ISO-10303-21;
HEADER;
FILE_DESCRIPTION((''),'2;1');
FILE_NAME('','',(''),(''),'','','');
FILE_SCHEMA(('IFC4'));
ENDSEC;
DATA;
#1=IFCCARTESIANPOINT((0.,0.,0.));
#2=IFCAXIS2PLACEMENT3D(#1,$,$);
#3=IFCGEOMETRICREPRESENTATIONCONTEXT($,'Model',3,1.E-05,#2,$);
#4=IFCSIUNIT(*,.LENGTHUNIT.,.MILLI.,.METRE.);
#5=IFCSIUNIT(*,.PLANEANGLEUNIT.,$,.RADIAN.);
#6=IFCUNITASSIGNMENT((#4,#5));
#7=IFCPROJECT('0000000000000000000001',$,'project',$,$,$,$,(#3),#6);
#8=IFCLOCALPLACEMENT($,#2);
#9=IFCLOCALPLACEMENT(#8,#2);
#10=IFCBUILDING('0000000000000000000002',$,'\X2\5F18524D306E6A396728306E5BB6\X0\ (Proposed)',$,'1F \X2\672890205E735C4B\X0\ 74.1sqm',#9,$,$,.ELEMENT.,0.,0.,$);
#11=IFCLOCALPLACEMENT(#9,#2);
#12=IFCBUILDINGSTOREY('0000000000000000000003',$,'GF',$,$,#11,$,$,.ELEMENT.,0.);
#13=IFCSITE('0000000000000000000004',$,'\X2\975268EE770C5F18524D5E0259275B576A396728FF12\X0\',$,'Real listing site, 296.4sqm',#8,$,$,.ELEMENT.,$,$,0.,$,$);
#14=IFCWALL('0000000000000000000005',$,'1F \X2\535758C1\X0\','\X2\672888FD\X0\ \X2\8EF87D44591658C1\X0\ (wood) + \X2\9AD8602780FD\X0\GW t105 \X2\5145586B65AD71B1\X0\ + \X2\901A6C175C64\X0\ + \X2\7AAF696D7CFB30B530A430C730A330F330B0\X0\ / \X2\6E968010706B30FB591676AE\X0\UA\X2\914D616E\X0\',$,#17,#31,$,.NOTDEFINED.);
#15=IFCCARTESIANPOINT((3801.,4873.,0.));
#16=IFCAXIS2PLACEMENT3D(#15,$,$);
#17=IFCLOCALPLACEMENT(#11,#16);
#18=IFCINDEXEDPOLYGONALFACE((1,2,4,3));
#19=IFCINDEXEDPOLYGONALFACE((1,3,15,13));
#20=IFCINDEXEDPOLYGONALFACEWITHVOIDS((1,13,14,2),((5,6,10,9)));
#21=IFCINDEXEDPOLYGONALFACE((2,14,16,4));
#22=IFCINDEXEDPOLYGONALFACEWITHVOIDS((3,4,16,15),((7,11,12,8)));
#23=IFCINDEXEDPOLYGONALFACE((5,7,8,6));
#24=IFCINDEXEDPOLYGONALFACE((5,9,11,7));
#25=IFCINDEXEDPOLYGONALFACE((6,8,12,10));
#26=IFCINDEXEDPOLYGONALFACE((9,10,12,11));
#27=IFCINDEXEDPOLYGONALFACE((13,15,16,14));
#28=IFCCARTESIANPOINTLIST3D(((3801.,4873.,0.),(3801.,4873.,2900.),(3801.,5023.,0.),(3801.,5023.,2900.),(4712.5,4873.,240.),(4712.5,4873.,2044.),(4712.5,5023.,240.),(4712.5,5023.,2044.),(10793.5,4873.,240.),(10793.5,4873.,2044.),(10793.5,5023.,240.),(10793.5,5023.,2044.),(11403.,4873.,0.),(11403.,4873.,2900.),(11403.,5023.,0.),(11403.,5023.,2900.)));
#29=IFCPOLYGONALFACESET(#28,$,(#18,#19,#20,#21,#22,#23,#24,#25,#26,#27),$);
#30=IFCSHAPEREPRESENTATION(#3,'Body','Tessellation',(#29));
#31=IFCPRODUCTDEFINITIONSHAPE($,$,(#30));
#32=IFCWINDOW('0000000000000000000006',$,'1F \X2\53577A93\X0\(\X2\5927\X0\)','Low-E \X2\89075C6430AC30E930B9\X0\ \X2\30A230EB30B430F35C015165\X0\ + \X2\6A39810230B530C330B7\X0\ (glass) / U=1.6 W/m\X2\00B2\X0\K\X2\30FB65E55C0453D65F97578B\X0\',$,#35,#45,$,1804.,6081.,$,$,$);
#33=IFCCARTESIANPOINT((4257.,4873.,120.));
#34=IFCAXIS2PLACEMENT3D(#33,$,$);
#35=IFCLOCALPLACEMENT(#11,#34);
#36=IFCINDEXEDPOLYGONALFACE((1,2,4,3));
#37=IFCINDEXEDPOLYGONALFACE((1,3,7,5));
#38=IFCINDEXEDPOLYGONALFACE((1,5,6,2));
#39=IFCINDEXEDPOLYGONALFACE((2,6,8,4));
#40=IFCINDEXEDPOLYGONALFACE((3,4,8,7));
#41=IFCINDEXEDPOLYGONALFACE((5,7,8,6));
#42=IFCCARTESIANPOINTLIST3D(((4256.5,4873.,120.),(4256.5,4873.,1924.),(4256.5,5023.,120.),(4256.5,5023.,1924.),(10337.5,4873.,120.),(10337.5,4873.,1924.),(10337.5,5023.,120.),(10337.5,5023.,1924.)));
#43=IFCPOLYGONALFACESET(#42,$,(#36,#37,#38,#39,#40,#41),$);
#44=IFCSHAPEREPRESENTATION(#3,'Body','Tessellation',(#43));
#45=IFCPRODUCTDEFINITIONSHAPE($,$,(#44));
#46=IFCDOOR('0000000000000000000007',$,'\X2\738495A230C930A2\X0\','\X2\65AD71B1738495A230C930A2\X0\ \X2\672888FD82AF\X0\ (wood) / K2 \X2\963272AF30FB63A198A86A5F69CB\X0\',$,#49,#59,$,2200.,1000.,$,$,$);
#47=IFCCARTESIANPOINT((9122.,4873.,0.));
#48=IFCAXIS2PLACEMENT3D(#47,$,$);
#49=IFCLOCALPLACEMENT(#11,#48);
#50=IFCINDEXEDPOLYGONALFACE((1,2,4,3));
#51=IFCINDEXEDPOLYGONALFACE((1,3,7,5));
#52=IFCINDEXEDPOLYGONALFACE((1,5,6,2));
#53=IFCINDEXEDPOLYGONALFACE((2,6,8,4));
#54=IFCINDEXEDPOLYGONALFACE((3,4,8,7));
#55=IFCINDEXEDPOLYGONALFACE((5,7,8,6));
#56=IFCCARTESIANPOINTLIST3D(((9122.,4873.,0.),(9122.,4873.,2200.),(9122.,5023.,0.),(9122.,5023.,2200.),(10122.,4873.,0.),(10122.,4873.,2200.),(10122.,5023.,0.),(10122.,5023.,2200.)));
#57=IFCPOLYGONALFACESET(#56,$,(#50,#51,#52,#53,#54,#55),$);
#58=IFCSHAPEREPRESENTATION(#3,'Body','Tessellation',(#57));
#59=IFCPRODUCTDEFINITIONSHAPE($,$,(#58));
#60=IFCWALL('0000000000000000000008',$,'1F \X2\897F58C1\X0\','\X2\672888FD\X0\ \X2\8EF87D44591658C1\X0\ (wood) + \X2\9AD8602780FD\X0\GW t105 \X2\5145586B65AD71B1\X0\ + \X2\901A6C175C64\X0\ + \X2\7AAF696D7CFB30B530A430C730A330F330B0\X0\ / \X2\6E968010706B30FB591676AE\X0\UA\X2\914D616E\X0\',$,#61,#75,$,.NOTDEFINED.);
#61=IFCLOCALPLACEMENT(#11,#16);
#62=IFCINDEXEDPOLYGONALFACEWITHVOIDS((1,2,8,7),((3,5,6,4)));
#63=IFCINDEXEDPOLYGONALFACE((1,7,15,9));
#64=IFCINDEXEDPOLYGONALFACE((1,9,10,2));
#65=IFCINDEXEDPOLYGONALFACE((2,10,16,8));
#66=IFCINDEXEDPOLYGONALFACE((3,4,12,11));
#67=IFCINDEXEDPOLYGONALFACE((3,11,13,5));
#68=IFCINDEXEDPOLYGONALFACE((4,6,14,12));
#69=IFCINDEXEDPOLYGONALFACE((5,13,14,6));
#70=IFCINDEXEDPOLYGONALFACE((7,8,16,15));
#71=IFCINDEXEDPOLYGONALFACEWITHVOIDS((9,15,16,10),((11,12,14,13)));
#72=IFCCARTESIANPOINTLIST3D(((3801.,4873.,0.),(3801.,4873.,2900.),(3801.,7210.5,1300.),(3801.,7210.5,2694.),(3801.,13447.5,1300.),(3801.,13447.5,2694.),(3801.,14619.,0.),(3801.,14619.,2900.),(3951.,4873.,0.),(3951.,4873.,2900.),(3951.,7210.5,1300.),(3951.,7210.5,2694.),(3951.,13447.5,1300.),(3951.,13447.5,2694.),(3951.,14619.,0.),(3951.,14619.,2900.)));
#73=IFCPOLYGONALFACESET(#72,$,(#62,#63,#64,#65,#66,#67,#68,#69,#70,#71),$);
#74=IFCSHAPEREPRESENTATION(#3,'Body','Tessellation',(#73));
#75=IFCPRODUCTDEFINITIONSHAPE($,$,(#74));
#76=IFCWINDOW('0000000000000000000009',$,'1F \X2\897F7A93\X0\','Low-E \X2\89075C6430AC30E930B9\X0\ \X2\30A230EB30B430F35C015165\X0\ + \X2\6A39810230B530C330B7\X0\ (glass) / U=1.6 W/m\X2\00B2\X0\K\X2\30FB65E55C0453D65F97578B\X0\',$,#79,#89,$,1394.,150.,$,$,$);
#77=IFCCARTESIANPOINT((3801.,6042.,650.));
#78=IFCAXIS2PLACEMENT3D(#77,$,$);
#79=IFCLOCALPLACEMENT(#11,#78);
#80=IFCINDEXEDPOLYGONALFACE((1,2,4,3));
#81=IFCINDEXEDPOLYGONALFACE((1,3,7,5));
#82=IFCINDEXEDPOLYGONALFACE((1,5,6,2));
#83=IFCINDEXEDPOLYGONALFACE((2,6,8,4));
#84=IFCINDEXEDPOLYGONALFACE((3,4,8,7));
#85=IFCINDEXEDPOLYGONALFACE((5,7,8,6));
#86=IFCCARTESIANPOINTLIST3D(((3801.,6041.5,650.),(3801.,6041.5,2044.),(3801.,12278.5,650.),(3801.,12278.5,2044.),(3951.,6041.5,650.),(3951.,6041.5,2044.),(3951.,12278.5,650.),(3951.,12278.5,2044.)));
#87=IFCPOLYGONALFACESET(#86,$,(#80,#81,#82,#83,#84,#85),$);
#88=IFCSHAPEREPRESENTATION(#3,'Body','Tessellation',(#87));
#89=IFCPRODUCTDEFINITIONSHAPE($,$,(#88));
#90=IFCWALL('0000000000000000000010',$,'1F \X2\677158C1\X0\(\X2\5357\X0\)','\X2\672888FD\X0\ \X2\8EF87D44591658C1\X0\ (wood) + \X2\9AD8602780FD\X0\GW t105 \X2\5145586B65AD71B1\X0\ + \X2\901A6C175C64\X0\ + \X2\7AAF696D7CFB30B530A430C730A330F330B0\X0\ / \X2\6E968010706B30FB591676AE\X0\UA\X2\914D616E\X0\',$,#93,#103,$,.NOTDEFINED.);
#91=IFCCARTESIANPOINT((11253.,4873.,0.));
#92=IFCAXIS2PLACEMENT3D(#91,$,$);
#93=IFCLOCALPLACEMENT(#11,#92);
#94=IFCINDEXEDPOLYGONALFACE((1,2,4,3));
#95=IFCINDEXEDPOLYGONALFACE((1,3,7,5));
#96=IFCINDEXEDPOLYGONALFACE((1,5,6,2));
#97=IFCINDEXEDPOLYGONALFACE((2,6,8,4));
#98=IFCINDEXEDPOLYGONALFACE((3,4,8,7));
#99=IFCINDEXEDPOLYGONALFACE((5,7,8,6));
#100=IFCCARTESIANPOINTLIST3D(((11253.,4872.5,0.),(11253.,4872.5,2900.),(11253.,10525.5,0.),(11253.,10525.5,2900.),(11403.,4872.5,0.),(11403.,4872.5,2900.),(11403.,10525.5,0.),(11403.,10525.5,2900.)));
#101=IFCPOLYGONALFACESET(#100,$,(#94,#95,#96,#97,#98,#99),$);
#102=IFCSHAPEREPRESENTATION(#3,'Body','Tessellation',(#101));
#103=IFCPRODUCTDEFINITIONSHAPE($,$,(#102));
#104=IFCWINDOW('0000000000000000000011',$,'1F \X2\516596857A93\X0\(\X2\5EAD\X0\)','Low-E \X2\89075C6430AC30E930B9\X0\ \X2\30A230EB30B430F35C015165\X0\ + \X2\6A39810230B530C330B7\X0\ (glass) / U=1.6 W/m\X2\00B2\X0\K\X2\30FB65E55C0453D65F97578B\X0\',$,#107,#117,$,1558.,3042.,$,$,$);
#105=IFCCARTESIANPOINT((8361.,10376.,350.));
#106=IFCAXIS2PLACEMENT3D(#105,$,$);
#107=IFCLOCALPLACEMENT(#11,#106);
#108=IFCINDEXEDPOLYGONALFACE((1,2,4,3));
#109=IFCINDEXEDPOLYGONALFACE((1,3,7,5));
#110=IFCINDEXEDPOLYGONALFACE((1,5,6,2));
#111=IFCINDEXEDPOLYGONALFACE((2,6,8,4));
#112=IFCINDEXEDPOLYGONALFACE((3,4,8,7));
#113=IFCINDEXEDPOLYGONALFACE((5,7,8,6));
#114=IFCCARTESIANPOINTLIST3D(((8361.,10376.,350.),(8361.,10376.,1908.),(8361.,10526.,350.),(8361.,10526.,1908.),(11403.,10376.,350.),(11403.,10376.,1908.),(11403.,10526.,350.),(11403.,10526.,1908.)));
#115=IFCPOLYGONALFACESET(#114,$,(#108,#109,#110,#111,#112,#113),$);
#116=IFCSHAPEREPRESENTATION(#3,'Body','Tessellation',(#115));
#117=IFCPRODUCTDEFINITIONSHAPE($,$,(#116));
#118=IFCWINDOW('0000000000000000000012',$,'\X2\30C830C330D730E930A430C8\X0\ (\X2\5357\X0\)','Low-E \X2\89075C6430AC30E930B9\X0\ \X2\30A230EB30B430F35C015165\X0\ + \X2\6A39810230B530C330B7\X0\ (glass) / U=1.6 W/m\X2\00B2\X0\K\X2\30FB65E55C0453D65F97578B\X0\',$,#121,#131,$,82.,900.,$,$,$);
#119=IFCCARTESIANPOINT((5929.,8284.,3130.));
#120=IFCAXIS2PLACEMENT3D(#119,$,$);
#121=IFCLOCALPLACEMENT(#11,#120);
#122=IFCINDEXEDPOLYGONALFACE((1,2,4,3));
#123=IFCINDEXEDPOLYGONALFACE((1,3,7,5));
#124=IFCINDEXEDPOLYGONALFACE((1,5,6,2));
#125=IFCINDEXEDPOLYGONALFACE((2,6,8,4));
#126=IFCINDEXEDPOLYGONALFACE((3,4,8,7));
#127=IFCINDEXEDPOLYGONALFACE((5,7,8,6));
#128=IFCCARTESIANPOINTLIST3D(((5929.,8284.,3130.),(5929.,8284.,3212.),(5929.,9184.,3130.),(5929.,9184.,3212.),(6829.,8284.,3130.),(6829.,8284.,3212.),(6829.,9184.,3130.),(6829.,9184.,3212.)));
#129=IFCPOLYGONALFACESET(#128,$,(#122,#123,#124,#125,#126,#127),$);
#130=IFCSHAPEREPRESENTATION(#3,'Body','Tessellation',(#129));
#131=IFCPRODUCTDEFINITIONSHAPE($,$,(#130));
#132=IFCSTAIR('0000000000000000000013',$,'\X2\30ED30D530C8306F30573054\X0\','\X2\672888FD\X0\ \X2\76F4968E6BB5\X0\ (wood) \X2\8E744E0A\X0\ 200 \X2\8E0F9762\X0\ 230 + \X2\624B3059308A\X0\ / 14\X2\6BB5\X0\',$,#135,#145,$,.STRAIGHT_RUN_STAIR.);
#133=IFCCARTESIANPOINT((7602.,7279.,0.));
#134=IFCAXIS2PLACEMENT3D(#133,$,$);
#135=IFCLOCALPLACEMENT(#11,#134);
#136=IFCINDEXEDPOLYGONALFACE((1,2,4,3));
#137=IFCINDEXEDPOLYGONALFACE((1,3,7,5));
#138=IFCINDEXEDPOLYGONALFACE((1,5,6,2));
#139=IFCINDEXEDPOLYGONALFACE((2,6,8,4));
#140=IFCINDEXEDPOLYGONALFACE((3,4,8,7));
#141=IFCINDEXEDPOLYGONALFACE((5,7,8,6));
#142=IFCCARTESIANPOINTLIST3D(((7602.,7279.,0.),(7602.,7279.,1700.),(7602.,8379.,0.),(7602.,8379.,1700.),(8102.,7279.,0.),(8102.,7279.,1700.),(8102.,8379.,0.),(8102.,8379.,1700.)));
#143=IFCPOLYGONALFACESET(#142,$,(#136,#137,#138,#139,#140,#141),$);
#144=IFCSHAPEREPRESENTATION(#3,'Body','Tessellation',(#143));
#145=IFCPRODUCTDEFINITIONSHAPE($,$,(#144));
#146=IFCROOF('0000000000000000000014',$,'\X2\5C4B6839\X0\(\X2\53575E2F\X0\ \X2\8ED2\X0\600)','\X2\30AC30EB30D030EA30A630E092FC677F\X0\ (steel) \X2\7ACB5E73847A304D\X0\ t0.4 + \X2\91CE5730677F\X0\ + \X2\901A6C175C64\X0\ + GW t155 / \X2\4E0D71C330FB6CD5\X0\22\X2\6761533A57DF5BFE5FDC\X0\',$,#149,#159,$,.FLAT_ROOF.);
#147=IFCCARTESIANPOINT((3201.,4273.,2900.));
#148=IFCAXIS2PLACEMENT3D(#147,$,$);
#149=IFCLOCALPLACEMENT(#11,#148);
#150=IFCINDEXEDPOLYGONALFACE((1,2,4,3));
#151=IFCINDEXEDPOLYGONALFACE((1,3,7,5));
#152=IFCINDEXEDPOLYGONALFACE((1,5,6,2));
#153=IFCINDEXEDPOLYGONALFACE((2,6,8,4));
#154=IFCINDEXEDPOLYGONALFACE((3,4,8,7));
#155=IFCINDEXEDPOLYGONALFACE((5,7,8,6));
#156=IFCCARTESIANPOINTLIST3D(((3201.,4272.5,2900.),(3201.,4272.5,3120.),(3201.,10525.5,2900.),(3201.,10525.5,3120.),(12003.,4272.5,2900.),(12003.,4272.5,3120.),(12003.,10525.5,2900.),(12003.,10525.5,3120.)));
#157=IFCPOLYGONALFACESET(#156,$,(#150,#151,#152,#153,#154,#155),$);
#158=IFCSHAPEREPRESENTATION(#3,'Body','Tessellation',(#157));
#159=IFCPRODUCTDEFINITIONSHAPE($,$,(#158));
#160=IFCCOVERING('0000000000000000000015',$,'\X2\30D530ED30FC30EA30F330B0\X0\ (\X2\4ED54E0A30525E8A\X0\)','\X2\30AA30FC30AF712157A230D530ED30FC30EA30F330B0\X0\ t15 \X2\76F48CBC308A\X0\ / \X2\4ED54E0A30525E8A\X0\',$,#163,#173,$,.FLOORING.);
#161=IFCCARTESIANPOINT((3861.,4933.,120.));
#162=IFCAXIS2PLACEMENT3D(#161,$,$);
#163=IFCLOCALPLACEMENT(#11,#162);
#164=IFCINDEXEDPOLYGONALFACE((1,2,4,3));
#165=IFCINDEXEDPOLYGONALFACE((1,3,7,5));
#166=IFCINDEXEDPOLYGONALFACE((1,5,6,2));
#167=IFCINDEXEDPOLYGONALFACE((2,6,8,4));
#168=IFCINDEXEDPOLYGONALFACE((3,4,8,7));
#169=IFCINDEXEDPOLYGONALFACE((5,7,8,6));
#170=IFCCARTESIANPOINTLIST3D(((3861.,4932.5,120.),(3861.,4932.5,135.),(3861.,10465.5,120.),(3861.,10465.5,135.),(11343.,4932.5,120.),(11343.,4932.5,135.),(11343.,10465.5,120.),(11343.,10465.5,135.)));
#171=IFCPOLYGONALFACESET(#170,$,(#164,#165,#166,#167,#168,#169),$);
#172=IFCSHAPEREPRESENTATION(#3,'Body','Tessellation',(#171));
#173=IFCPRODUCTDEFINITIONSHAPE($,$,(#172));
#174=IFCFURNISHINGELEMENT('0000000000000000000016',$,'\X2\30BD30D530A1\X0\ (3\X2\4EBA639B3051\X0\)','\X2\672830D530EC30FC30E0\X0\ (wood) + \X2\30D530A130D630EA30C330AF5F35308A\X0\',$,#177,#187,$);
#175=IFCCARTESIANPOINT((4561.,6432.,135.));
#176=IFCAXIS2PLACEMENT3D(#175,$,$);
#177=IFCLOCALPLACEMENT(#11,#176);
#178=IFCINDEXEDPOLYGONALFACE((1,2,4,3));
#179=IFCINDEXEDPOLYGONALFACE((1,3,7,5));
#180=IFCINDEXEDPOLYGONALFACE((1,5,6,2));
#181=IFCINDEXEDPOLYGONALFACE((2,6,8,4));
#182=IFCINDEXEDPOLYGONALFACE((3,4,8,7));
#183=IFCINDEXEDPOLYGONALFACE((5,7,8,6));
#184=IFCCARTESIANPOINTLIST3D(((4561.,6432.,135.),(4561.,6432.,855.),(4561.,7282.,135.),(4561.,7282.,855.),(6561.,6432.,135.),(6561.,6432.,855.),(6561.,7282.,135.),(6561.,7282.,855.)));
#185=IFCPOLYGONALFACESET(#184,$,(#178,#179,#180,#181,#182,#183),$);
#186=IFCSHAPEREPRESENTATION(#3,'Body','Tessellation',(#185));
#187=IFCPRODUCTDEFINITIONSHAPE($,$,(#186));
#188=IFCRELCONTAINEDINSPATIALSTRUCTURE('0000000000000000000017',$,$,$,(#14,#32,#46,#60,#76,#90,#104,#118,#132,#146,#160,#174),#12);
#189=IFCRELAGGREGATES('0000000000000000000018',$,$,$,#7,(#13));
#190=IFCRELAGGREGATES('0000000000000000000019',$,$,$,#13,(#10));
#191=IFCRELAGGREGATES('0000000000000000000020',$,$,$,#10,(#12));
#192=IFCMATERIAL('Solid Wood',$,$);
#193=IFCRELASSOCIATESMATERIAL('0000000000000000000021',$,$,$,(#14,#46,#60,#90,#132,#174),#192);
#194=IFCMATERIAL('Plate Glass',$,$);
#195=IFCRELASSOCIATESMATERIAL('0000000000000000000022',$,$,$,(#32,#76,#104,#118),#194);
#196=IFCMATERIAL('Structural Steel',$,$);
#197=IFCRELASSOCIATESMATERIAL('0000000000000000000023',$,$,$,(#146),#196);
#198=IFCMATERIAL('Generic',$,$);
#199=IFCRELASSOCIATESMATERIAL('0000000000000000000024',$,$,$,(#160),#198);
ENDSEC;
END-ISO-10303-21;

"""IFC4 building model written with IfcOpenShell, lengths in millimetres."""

from ifc_helpers import new_model, si_unit, frame, frame_2d, origin, place, context, project, spatial, rectangle, extrude, material, element, fill, save


model = new_model("IFC4")

# Units and contexts
model_context = context("Model", 3, precision=1e-05, world=origin())
ifc_project = project(units=[si_unit("LENGTHUNIT", "METRE", prefix="MILLI"), si_unit("PLANEANGLEUNIT", "RADIAN")], contexts=[model_context])

# Site, building, storey
site_placement = place(None, origin())
site = spatial("IfcSite", under=ifc_project, at=site_placement, Name="青森県弘前市大字樹木２", ObjectType="Real listing site, 296.4sqm", CompositionType="ELEMENT", RefElevation=0.0)
building_placement = place(site_placement, origin())
building = spatial("IfcBuilding", under=site, at=building_placement, Name="弘前の樹木の家 (Proposed)", ObjectType="1F 木造平屋 74.1sqm", CompositionType="ELEMENT", ElevationOfRefHeight=0.0, ElevationOfTerrain=0.0)
storey_placement = place(building_placement, origin())
storey = spatial("IfcBuildingStorey", under=building, at=storey_placement, Name="GF", CompositionType="ELEMENT", Elevation=0.0)

# Shared definitions
ifc_material_1 = material(Name="Solid Wood")

# Wall, openings, window, door
wall_1_placement = place(storey_placement, frame((3801.0, 4873.0, 0.0)))
wall_1 = element("IfcWall", 1, at=wall_1_placement, inside=storey, material=ifc_material_1, Name="1F 南壁", Description="木製 軸組外壁 (wood) + 高性能GW t105 充填断熱 + 通気層 + 窯業系サイディング / 準耐火・外皮UA配慮", PredefinedType="NOTDEFINED", context=model_context, shape_type="SweptSolid", body=[
    extrude(rectangle(XDim=7602.0, YDim=150.0, at=frame_2d((3801.0, 75.0))), frame((3801.0, 4873.0, 0.0)), (0.0, 0.0, 1.0), 2900.0),
])
opening_1_placement = place(storey_placement, frame((4257.0, 4873.0, 120.0)))
opening_1 = element("IfcOpeningElement", 2, at=opening_1_placement, cuts=wall_1, PredefinedType="NOTDEFINED", context=model_context, shape_type="SweptSolid", body=[
    extrude(rectangle(XDim=6081.0, YDim=150.0, at=frame_2d((3040.0, 75.0))), frame((4257.0, 4873.0, 120.0)), (0.0, 0.0, 1.0), 1804.0),
])
opening_2_placement = place(storey_placement, frame((9122.0, 4873.0, 0.0)))
opening_2 = element("IfcOpeningElement", 3, at=opening_2_placement, cuts=wall_1, PredefinedType="NOTDEFINED", context=model_context, shape_type="SweptSolid", body=[
    extrude(rectangle(XDim=1000.0, YDim=150.0, at=frame_2d((500.0, 75.0))), frame((9122.0, 4873.0, 0.0)), (0.0, 0.0, 1.0), 2200.0),
])
ifc_material_2 = material(Name="Plate Glass")
window_1_placement = place(storey_placement, frame((4257.0, 4873.0, 120.0)))
window_1 = element("IfcWindow", 4, at=window_1_placement, inside=storey, material=ifc_material_2, Name="1F 南窓(大)", Description="Low-E 複層ガラス アルゴン封入 + 樹脂サッシ (glass) / U=1.6 W/m²K・日射取得型", OverallHeight=1804.0, OverallWidth=6081.0, context=model_context, shape_type="SweptSolid", body=[
    extrude(rectangle(XDim=6081.0, YDim=150.0, at=frame_2d((3040.0, 75.0))), frame((4257.0, 4873.0, 120.0)), (0.0, 0.0, 1.0), 1804.0),
])
fill(opening_1, window_1)
door_1_placement = place(storey_placement, frame((9122.0, 4873.0, 0.0)))
door_1 = element("IfcDoor", 5, at=door_1_placement, inside=storey, material=ifc_material_1, Name="玄関ドア", Description="断熱玄関ドア 木製芯 (wood) / K2 防犯・採風機構", OverallHeight=2200.0, OverallWidth=1000.0, context=model_context, shape_type="SweptSolid", body=[
    extrude(rectangle(XDim=1000.0, YDim=150.0, at=frame_2d((500.0, 75.0))), frame((9122.0, 4873.0, 0.0)), (0.0, 0.0, 1.0), 2200.0),
])
fill(opening_2, door_1)

# Walls, openings, windows
wall_2_placement = place(storey_placement, frame((3801.0, 4873.0, 0.0)))
wall_2 = element("IfcWall", 6, at=wall_2_placement, inside=storey, material=ifc_material_1, Name="1F 西壁", Description="木製 軸組外壁 (wood) + 高性能GW t105 充填断熱 + 通気層 + 窯業系サイディング / 準耐火・外皮UA配慮", PredefinedType="NOTDEFINED", context=model_context, shape_type="SweptSolid", body=[
    extrude(rectangle(XDim=150.0, YDim=9746.0, at=frame_2d((75.0, 4873.0))), frame((3801.0, 4873.0, 0.0)), (0.0, 0.0, 1.0), 2900.0),
])
opening_3_placement = place(storey_placement, frame((3801.0, 6042.0, 650.0)))
opening_3 = element("IfcOpeningElement", 7, at=opening_3_placement, cuts=wall_2, PredefinedType="NOTDEFINED", context=model_context, shape_type="SweptSolid", body=[
    extrude(rectangle(XDim=150.0, YDim=6237.0, at=frame_2d((75.0, 3118.0))), frame((3801.0, 6042.0, 650.0)), (0.0, 0.0, 1.0), 1394.0),
])
window_2_placement = place(storey_placement, frame((3801.0, 6042.0, 650.0)))
window_2 = element("IfcWindow", 8, at=window_2_placement, inside=storey, material=ifc_material_2, Name="1F 西窓", Description="Low-E 複層ガラス アルゴン封入 + 樹脂サッシ (glass) / U=1.6 W/m²K・日射取得型", OverallHeight=1394.0, OverallWidth=150.0, context=model_context, shape_type="SweptSolid", body=[
    extrude(rectangle(XDim=150.0, YDim=6237.0, at=frame_2d((75.0, 3118.0))), frame((3801.0, 6042.0, 650.0)), (0.0, 0.0, 1.0), 1394.0),
])
fill(opening_3, window_2)
wall_3_placement = place(storey_placement, frame((11253.0, 4873.0, 0.0)))
wall_3 = element("IfcWall", 9, at=wall_3_placement, inside=storey, material=ifc_material_1, Name="1F 東壁(南)", Description="木製 軸組外壁 (wood) + 高性能GW t105 充填断熱 + 通気層 + 窯業系サイディング / 準耐火・外皮UA配慮", PredefinedType="NOTDEFINED", context=model_context, shape_type="SweptSolid", body=[
    extrude(rectangle(XDim=150.0, YDim=5653.0, at=frame_2d((75.0, 2826.0))), frame((11253.0, 4873.0, 0.0)), (0.0, 0.0, 1.0), 2900.0),
])
opening_4_placement = place(storey_placement, frame((8361.0, 10376.0, 350.0)))
opening_4 = element("IfcOpeningElement", 10, at=opening_4_placement, cuts=wall_3, PredefinedType="NOTDEFINED", context=model_context, shape_type="SweptSolid", body=[
    extrude(rectangle(XDim=3042.0, YDim=150.0, at=frame_2d((1521.0, 75.0))), frame((8361.0, 10376.0, 350.0)), (0.0, 0.0, 1.0), 1558.0),
])
window_3_placement = place(storey_placement, frame((8361.0, 10376.0, 350.0)))
window_3 = element("IfcWindow", 11, at=window_3_placement, inside=storey, material=ifc_material_2, Name="1F 入隅窓(庭)", Description="Low-E 複層ガラス アルゴン封入 + 樹脂サッシ (glass) / U=1.6 W/m²K・日射取得型", OverallHeight=1558.0, OverallWidth=3042.0, context=model_context, shape_type="SweptSolid", body=[
    extrude(rectangle(XDim=3042.0, YDim=150.0, at=frame_2d((1521.0, 75.0))), frame((8361.0, 10376.0, 350.0)), (0.0, 0.0, 1.0), 1558.0),
])
fill(opening_4, window_3)

# Window
window_4_placement = place(storey_placement, frame((5929.0, 8284.0, 3130.0)))
element("IfcWindow", 12, at=window_4_placement, inside=storey, material=ifc_material_2, Name="トップライト (南)", Description="Low-E 複層ガラス アルゴン封入 + 樹脂サッシ (glass) / U=1.6 W/m²K・日射取得型", OverallHeight=82.0, OverallWidth=900.0, context=model_context, shape_type="SweptSolid", body=[
    extrude(rectangle(XDim=900.0, YDim=900.0, at=frame_2d((450.0, 450.0))), frame((5929.0, 8284.0, 3130.0)), (0.0, 0.0, 1.0), 82.0),
])

# Stair
stair_placement = place(storey_placement, frame((7602.0, 7279.0, 0.0)))
element("IfcStair", 13, at=stair_placement, inside=storey, material=ifc_material_1, Name="ロフトはしご", Description="木製 直階段 (wood) 蹴上 200 踏面 230 + 手すり / 14段", PredefinedType="STRAIGHT_RUN_STAIR", context=model_context, shape_type="SweptSolid", body=[
    extrude(rectangle(XDim=500.0, YDim=1100.0, at=frame_2d((250.0, 550.0))), frame((7602.0, 7279.0, 0.0)), (0.0, 0.0, 1.0), 1700.0),
])

# Roof
ifc_material_3 = material(Name="Structural Steel")
roof_placement = place(storey_placement, frame((3201.0, 4273.0, 2900.0)))
element("IfcRoof", 14, at=roof_placement, inside=storey, material=ifc_material_3, Name="屋根(南帯 軒600)", Description="ガルバリウム鋼板 (steel) 立平葺き t0.4 + 野地板 + 通気層 + GW t155 / 不燃・法22条区域対応", PredefinedType="FLAT_ROOF", context=model_context, shape_type="SweptSolid", body=[
    extrude(rectangle(XDim=8802.0, YDim=6253.0, at=frame_2d((4401.0, 3126.0))), frame((3201.0, 4273.0, 2900.0)), (0.0, 0.0, 1.0), 220.0),
])

# Covering
ifc_material_4 = material(Name="Generic")
covering_placement = place(storey_placement, frame((3861.0, 4933.0, 120.0)))
element("IfcCovering", 15, at=covering_placement, inside=storey, material=ifc_material_4, Name="フローリング (仕上げ床)", Description="オーク無垢フローリング t15 直貼り / 仕上げ床", PredefinedType="FLOORING", context=model_context, shape_type="SweptSolid", body=[
    extrude(rectangle(XDim=7482.0, YDim=5533.0, at=frame_2d((3741.0, 2766.0))), frame((3861.0, 4933.0, 120.0)), (0.0, 0.0, 1.0), 15.0),
])

# Furnishing element
furnishing_1_placement = place(storey_placement, frame((4561.0, 6432.0, 135.0)))
element("IfcFurnishingElement", 16, at=furnishing_1_placement, inside=storey, material=ifc_material_1, Name="ソファ (3人掛け)", Description="木フレーム (wood) + ファブリック張り", context=model_context, shape_type="SweptSolid", body=[
    extrude(rectangle(XDim=2000.0, YDim=850.0, at=frame_2d((1000.0, 425.0))), frame((4561.0, 6432.0, 135.0)), (0.0, 0.0, 1.0), 720.0),
])

save(model, "model.ifc")
